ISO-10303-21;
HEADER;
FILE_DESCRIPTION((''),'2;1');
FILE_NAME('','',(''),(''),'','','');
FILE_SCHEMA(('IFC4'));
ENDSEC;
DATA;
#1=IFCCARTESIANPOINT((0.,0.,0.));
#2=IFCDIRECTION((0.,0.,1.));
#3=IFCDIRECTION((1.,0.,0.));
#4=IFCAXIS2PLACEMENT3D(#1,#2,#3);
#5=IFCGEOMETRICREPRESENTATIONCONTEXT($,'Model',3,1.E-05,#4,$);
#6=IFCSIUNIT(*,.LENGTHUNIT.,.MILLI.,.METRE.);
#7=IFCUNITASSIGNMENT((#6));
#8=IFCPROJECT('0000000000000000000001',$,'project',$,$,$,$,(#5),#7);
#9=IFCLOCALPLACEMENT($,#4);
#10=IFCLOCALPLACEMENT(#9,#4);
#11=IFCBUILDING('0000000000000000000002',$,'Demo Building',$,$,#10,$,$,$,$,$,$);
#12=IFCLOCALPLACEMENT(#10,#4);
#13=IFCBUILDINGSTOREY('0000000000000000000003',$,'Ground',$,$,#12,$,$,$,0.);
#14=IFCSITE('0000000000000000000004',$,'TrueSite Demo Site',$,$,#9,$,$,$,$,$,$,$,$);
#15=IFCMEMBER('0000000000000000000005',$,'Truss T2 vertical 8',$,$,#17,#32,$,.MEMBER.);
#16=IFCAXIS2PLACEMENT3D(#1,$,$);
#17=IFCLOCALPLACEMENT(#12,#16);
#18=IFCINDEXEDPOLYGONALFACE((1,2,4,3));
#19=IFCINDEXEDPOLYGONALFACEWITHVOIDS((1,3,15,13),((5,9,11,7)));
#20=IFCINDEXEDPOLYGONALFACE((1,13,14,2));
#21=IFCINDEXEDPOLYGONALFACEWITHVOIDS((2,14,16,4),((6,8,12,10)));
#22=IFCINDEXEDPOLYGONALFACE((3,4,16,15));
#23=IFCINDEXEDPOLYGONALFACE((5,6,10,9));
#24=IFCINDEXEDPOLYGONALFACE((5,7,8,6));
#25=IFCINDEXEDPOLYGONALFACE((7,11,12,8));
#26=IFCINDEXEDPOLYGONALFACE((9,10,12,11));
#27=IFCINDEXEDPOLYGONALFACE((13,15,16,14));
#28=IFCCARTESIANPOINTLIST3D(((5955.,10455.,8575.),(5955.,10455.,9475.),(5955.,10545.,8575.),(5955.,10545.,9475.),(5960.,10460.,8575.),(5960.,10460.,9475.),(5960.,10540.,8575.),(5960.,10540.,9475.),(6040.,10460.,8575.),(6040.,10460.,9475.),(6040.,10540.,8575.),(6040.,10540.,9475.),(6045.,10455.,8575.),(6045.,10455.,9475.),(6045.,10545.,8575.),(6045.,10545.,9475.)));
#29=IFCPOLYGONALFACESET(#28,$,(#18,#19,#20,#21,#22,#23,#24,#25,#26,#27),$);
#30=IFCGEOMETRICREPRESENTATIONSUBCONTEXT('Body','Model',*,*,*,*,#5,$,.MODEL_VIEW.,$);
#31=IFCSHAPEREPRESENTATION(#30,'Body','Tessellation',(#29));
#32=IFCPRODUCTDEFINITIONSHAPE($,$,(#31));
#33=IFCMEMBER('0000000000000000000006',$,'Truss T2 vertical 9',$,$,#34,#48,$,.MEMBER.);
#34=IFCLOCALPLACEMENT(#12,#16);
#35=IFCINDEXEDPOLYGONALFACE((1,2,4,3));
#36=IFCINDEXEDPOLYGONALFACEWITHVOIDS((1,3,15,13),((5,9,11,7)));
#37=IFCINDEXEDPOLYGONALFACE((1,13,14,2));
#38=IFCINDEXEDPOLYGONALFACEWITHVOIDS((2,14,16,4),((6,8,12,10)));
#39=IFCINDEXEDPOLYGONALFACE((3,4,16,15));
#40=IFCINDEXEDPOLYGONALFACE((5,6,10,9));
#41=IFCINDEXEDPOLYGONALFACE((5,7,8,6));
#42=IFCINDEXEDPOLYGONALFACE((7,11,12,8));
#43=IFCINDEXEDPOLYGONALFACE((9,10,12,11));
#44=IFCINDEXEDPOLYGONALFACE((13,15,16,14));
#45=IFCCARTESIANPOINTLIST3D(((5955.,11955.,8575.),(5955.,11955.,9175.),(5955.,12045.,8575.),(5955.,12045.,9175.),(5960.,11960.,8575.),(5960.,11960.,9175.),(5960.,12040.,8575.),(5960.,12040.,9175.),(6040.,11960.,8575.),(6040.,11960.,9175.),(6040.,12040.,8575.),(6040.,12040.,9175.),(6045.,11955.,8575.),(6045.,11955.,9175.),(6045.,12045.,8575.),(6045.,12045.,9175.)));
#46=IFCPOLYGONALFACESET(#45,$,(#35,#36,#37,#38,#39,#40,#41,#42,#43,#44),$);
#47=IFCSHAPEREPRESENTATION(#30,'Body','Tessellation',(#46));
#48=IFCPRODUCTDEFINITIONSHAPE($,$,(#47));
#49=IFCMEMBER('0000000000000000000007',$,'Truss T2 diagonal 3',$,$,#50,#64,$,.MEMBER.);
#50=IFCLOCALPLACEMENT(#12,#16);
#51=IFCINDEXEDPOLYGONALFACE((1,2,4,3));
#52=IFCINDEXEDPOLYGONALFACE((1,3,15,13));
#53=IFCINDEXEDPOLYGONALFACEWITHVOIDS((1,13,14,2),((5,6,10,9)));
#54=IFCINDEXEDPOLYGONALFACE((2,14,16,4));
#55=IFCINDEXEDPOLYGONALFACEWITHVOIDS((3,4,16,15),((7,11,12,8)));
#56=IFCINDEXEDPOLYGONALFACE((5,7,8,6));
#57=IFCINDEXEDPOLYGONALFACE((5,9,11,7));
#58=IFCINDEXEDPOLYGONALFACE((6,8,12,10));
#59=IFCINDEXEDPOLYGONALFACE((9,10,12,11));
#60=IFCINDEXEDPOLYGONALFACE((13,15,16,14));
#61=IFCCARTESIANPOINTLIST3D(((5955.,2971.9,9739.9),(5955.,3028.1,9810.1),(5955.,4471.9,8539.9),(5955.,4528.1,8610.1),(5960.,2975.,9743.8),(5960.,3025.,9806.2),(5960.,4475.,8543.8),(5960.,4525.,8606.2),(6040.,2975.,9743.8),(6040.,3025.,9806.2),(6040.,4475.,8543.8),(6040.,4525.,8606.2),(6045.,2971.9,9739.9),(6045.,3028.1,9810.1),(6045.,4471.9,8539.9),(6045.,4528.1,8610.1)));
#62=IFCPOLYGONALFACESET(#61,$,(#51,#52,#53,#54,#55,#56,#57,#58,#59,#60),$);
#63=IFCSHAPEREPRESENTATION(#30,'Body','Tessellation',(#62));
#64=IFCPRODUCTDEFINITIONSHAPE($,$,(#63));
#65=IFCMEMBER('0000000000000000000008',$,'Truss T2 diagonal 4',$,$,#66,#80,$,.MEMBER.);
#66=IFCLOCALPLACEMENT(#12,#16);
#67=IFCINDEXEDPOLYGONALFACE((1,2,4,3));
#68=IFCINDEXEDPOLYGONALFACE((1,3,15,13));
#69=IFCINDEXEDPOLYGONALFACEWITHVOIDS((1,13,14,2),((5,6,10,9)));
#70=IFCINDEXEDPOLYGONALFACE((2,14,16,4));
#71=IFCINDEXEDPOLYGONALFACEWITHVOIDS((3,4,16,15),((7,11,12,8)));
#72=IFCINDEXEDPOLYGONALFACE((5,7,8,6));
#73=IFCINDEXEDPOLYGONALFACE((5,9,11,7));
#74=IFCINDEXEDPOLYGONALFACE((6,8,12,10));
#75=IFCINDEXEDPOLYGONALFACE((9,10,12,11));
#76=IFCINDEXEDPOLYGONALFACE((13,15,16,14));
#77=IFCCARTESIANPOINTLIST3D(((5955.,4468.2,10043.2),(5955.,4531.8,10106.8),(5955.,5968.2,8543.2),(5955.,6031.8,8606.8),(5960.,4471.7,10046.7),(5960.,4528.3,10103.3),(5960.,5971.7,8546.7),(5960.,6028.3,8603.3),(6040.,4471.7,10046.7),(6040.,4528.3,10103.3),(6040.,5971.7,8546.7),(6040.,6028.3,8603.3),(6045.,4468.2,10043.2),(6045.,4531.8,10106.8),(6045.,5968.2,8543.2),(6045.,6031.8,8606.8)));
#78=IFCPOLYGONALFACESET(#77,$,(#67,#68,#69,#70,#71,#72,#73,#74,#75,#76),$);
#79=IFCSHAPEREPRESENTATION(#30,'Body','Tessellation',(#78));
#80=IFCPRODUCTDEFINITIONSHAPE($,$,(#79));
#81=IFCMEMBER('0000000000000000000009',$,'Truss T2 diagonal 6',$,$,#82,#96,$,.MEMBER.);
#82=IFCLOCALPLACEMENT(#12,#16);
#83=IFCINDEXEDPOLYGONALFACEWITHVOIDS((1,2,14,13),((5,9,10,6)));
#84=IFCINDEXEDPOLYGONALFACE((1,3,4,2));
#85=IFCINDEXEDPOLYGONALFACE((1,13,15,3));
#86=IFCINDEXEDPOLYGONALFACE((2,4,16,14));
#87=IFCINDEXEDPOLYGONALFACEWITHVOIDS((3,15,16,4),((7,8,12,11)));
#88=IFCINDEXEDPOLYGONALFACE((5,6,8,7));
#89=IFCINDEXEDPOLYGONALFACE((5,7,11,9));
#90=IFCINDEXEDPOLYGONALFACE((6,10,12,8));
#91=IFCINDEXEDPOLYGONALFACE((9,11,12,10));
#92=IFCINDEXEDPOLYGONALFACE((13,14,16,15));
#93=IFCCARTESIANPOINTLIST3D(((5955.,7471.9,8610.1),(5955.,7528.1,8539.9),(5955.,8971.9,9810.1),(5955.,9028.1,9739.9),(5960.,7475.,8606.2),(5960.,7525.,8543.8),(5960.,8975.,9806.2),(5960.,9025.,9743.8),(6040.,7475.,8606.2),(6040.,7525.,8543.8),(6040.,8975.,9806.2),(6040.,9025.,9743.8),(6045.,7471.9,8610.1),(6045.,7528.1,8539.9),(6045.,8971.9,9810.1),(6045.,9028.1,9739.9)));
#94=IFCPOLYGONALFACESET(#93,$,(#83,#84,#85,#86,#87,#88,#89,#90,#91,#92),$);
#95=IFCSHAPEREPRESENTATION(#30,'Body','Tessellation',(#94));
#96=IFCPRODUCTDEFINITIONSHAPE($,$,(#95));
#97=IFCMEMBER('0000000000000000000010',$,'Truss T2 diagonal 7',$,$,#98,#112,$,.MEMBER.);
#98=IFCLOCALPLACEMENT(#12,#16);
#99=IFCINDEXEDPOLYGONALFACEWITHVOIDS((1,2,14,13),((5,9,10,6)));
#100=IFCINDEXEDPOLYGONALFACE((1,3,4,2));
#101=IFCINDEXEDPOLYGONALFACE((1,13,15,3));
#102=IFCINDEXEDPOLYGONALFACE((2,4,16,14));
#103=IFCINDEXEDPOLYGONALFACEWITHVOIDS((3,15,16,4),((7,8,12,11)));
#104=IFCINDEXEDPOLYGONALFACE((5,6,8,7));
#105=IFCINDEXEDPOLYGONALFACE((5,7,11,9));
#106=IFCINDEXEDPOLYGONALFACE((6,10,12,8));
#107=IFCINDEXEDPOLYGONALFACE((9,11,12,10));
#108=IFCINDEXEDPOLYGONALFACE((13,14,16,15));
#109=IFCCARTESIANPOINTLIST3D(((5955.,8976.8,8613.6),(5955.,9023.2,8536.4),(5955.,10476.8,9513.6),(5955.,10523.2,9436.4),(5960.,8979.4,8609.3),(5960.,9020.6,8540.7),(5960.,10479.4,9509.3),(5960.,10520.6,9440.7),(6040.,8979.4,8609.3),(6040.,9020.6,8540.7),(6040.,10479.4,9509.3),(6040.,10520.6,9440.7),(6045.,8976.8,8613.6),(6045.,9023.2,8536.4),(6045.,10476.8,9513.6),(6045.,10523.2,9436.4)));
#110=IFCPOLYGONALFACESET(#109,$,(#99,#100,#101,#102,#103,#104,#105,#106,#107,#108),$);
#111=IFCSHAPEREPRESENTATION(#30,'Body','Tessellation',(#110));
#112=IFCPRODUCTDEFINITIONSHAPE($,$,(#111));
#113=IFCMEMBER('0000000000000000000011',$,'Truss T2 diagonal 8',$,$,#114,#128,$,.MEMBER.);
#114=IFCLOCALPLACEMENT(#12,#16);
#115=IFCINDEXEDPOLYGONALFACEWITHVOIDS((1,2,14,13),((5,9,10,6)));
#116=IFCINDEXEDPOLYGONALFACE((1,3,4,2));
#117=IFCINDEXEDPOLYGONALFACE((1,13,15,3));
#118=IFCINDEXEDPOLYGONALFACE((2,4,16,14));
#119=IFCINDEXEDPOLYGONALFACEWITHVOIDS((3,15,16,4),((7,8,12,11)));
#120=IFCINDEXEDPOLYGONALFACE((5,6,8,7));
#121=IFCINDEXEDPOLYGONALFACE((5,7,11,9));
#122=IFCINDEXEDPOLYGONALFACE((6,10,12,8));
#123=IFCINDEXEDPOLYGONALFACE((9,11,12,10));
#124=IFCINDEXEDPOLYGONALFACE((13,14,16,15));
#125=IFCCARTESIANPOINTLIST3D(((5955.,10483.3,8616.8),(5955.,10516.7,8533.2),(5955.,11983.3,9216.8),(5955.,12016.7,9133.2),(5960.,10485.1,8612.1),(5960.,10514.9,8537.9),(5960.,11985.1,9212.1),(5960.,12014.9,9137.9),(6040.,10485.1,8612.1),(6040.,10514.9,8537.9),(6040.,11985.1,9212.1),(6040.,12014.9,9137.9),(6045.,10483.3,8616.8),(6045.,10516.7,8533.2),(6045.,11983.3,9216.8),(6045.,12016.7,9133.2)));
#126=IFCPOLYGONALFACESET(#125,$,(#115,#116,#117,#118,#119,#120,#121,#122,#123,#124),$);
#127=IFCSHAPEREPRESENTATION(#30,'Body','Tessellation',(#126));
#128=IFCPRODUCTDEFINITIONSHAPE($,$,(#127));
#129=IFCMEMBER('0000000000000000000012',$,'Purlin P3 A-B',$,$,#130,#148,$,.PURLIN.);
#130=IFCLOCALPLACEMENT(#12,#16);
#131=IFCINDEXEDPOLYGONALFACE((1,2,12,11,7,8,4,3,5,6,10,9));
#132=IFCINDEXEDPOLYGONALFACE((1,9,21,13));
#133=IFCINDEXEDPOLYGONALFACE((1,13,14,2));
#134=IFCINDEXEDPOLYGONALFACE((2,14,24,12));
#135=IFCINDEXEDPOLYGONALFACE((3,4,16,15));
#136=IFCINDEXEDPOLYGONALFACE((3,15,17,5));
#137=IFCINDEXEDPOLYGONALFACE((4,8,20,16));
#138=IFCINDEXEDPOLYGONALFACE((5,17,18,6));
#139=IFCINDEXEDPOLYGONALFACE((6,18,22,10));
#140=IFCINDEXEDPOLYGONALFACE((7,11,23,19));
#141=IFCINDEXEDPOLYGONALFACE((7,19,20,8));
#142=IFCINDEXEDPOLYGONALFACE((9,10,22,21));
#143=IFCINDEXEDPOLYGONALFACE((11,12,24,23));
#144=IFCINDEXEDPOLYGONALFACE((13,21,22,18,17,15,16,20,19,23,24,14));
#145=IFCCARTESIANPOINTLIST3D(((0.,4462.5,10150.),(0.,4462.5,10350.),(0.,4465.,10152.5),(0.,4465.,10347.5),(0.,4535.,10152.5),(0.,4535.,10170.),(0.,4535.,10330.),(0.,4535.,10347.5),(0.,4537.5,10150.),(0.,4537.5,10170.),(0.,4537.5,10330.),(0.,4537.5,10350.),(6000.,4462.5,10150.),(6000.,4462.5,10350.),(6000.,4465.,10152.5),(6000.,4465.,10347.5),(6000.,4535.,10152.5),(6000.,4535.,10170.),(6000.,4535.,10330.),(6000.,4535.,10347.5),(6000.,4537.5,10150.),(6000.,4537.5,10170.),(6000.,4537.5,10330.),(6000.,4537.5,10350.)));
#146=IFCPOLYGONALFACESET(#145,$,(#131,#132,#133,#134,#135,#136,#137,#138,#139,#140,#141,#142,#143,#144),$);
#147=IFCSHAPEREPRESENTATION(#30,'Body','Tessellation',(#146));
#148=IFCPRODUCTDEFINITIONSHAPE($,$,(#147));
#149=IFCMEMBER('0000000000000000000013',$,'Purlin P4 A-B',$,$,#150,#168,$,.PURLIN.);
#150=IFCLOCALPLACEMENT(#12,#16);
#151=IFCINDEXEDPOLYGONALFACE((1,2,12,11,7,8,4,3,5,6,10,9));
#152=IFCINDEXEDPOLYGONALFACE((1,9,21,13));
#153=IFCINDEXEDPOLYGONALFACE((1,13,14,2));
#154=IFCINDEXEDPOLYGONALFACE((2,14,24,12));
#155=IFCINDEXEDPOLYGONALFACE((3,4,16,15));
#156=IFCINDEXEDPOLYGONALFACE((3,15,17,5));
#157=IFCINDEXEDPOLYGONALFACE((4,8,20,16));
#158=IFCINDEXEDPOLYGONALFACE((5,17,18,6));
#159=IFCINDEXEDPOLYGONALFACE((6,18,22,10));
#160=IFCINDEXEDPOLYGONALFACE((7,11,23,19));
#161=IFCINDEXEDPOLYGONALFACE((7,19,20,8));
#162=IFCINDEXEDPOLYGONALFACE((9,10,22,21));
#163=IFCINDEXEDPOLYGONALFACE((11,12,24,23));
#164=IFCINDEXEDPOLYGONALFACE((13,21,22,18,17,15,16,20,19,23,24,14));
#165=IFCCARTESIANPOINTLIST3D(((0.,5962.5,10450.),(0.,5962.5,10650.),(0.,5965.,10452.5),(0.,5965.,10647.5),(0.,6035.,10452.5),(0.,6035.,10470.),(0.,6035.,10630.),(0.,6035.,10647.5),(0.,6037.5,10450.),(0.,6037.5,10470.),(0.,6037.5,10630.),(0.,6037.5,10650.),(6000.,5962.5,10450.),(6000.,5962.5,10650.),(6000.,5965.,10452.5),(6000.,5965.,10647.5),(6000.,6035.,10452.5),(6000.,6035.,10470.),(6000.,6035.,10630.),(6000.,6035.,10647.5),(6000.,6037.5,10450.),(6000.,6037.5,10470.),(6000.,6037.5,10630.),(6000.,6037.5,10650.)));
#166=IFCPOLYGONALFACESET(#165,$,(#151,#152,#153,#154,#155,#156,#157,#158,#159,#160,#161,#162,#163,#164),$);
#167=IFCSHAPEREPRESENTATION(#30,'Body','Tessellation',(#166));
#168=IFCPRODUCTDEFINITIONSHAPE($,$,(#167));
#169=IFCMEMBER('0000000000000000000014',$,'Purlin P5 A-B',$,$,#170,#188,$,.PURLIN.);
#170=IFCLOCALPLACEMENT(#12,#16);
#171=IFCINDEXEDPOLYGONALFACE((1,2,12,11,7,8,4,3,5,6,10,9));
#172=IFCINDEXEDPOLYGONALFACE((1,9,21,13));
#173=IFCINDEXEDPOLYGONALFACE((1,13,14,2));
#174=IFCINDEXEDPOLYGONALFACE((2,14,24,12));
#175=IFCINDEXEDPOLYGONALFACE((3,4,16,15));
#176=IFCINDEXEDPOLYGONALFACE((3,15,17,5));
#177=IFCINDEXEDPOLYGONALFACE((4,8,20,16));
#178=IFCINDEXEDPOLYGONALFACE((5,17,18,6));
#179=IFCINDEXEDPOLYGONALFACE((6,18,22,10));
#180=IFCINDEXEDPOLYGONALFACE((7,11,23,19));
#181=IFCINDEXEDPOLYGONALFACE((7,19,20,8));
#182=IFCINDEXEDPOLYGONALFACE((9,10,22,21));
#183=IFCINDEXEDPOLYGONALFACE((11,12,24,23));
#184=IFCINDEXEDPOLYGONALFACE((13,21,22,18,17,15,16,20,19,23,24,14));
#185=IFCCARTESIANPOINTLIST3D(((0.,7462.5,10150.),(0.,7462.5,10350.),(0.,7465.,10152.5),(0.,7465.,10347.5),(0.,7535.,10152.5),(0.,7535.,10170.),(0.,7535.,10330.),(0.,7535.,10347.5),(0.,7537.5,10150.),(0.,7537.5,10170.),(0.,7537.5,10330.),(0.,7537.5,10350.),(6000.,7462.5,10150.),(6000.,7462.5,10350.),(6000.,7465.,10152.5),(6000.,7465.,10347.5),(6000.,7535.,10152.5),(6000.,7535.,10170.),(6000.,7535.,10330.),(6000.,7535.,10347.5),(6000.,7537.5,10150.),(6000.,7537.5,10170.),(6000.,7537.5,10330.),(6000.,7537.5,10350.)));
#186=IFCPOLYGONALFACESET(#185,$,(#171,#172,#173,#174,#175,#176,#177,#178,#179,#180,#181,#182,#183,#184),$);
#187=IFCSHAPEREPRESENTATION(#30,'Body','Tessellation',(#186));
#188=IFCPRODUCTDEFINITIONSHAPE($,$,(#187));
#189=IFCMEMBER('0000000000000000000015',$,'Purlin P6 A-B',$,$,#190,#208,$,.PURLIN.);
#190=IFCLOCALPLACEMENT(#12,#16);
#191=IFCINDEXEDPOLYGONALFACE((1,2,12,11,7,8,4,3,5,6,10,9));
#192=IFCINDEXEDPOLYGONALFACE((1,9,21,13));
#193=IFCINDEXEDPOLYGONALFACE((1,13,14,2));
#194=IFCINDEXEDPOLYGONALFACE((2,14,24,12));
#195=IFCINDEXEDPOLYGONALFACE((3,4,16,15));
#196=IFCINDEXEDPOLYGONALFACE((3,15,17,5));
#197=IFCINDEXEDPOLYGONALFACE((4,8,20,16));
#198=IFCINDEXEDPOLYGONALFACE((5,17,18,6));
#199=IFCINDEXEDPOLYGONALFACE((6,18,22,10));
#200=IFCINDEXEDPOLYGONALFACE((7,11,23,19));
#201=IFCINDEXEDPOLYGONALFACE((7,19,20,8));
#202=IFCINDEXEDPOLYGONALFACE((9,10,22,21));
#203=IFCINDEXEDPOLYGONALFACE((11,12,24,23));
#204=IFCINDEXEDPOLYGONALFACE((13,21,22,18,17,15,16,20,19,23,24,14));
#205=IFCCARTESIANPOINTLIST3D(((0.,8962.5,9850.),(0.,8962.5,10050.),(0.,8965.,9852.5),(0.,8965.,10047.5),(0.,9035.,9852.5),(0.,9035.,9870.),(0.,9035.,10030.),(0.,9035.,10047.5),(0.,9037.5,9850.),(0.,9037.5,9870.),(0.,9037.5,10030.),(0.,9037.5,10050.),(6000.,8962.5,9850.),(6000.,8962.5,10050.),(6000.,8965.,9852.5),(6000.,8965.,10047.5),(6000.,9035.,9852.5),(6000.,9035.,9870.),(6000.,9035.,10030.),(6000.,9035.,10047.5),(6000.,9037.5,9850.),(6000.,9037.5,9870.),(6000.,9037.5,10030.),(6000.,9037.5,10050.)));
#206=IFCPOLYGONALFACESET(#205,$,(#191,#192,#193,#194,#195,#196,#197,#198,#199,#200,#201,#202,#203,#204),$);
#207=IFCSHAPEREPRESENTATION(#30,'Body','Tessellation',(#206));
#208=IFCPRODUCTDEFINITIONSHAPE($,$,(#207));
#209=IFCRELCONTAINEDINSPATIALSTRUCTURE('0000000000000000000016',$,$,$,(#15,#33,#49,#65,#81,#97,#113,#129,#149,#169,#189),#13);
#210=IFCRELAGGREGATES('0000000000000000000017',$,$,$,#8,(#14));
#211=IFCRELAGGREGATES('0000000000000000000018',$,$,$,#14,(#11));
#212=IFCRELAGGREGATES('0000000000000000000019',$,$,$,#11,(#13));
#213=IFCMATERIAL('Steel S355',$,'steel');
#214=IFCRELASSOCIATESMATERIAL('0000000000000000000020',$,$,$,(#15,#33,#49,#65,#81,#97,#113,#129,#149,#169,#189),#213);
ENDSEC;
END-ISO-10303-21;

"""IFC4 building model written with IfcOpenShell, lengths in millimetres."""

from ifc_helpers import new_model, si_unit, frame, origin_with_axes, place, context, subcontext, project, spatial, hollow_rectangle, c_section, extrude, material, element, save


model = new_model("IFC4")

# Units and contexts
model_context = context("Model", 3, precision=1e-05, world=origin_with_axes())
body_context = subcontext(model_context, "Body", "Model", "MODEL_VIEW")
ifc_project = project(units=[si_unit("LENGTHUNIT", "METRE", prefix="MILLI")], contexts=[model_context])

# Site, building, storey
site_placement = place(None, origin_with_axes())
site = spatial("IfcSite", under=ifc_project, at=site_placement, Name="TrueSite Demo Site")
building_placement = place(site_placement, origin_with_axes())
building = spatial("IfcBuilding", under=site, at=building_placement, Name="Demo Building")
storey_placement = place(building_placement, origin_with_axes())
storey = spatial("IfcBuildingStorey", under=building, at=storey_placement, Name="Ground", Elevation=0.0)

# Members
ifc_material = material(Name="Steel S355", Category="steel")
member_1_placement = place(storey_placement, frame((6000.0, 10500.0, 8575.0), z_axis=(0.0, 0.0, 1.0), x_axis=(1.0, 0.0, 0.0)))
element("IfcMember", 1, at=member_1_placement, inside=storey, material=ifc_material, Name="Truss T2 vertical 8", PredefinedType="MEMBER", context=body_context, shape_type="SweptSolid", body=[
    extrude(hollow_rectangle(XDim=90.0, YDim=90.0, WallThickness=5.0), origin_with_axes(), (0.0, 0.0, 1.0), 900.0),
])
member_2_placement = place(storey_placement, frame((6000.0, 12000.0, 8575.0), z_axis=(0.0, 0.0, 1.0), x_axis=(1.0, 0.0, 0.0)))
element("IfcMember", 2, at=member_2_placement, inside=storey, material=ifc_material, Name="Truss T2 vertical 9", PredefinedType="MEMBER", context=body_context, shape_type="SweptSolid", body=[
    extrude(hollow_rectangle(XDim=90.0, YDim=90.0, WallThickness=5.0), origin_with_axes(), (0.0, 0.0, 1.0), 600.0),
])
member_3_placement = place(storey_placement, frame((6000.0, 3000.0, 9775.0), z_axis=(0.0, 0.780869, -0.624695), x_axis=(-1.0, 0.0, 0.0)))
element("IfcMember", 3, at=member_3_placement, inside=storey, material=ifc_material, Name="Truss T2 diagonal 3", PredefinedType="MEMBER", context=body_context, shape_type="SweptSolid", body=[
    extrude(hollow_rectangle(XDim=90.0, YDim=90.0, WallThickness=5.0), origin_with_axes(), (0.0, 0.0, 1.0), 1920.9),
])
member_4_placement = place(storey_placement, frame((6000.0, 4500.0, 10075.0), z_axis=(0.0, 0.707107, -0.707107), x_axis=(-1.0, 0.0, 0.0)))
element("IfcMember", 4, at=member_4_placement, inside=storey, material=ifc_material, Name="Truss T2 diagonal 4", PredefinedType="MEMBER", context=body_context, shape_type="SweptSolid", body=[
    extrude(hollow_rectangle(XDim=90.0, YDim=90.0, WallThickness=5.0), origin_with_axes(), (0.0, 0.0, 1.0), 2121.3),
])
member_5_placement = place(storey_placement, frame((6000.0, 7500.0, 8575.0), z_axis=(0.0, 0.780869, 0.624695), x_axis=(-1.0, 0.0, 0.0)))
element("IfcMember", 5, at=member_5_placement, inside=storey, material=ifc_material, Name="Truss T2 diagonal 6", PredefinedType="MEMBER", context=body_context, shape_type="SweptSolid", body=[
    extrude(hollow_rectangle(XDim=90.0, YDim=90.0, WallThickness=5.0), origin_with_axes(), (0.0, 0.0, 1.0), 1920.9),
])
member_6_placement = place(storey_placement, frame((6000.0, 9000.0, 8575.0), z_axis=(0.0, 0.857493, 0.514496), x_axis=(-1.0, 0.0, 0.0)))
element("IfcMember", 6, at=member_6_placement, inside=storey, material=ifc_material, Name="Truss T2 diagonal 7", PredefinedType="MEMBER", context=body_context, shape_type="SweptSolid", body=[
    extrude(hollow_rectangle(XDim=90.0, YDim=90.0, WallThickness=5.0), origin_with_axes(), (0.0, 0.0, 1.0), 1749.3),
])
member_7_placement = place(storey_placement, frame((6000.0, 10500.0, 8575.0), z_axis=(0.0, 0.928477, 0.371391), x_axis=(-1.0, 0.0, 0.0)))
element("IfcMember", 7, at=member_7_placement, inside=storey, material=ifc_material, Name="Truss T2 diagonal 8", PredefinedType="MEMBER", context=body_context, shape_type="SweptSolid", body=[
    extrude(hollow_rectangle(XDim=90.0, YDim=90.0, WallThickness=5.0), origin_with_axes(), (0.0, 0.0, 1.0), 1615.5),
])
for number, where, z_axis, x_axis, name in (
    (8, (0.0, 4500.0, 10250.0), (1.0, 0.0, 0.0), (0.0, 1.0, 0.0), "Purlin P3 A-B"),
    (9, (0.0, 6000.0, 10550.0), (1.0, 0.0, 0.0), (0.0, 1.0, 0.0), "Purlin P4 A-B"),
    (10, (0.0, 7500.0, 10250.0), (1.0, 0.0, 0.0), (0.0, 1.0, 0.0), "Purlin P5 A-B"),
    (11, (0.0, 9000.0, 9950.0), (1.0, 0.0, 0.0), (0.0, 1.0, 0.0), "Purlin P6 A-B"),
):
    element("IfcMember", number, at=place(storey_placement, frame(where, z_axis=z_axis, x_axis=x_axis)), inside=storey, material=ifc_material, Name=name, PredefinedType="PURLIN", context=body_context, shape_type="SweptSolid", body=[
        extrude(c_section(Depth=200.0, Width=75.0, WallThickness=2.5, Girth=20.0), origin_with_axes(), (0.0, 0.0, 1.0), 6000.0),
    ])

save(model, "model.ifc")
